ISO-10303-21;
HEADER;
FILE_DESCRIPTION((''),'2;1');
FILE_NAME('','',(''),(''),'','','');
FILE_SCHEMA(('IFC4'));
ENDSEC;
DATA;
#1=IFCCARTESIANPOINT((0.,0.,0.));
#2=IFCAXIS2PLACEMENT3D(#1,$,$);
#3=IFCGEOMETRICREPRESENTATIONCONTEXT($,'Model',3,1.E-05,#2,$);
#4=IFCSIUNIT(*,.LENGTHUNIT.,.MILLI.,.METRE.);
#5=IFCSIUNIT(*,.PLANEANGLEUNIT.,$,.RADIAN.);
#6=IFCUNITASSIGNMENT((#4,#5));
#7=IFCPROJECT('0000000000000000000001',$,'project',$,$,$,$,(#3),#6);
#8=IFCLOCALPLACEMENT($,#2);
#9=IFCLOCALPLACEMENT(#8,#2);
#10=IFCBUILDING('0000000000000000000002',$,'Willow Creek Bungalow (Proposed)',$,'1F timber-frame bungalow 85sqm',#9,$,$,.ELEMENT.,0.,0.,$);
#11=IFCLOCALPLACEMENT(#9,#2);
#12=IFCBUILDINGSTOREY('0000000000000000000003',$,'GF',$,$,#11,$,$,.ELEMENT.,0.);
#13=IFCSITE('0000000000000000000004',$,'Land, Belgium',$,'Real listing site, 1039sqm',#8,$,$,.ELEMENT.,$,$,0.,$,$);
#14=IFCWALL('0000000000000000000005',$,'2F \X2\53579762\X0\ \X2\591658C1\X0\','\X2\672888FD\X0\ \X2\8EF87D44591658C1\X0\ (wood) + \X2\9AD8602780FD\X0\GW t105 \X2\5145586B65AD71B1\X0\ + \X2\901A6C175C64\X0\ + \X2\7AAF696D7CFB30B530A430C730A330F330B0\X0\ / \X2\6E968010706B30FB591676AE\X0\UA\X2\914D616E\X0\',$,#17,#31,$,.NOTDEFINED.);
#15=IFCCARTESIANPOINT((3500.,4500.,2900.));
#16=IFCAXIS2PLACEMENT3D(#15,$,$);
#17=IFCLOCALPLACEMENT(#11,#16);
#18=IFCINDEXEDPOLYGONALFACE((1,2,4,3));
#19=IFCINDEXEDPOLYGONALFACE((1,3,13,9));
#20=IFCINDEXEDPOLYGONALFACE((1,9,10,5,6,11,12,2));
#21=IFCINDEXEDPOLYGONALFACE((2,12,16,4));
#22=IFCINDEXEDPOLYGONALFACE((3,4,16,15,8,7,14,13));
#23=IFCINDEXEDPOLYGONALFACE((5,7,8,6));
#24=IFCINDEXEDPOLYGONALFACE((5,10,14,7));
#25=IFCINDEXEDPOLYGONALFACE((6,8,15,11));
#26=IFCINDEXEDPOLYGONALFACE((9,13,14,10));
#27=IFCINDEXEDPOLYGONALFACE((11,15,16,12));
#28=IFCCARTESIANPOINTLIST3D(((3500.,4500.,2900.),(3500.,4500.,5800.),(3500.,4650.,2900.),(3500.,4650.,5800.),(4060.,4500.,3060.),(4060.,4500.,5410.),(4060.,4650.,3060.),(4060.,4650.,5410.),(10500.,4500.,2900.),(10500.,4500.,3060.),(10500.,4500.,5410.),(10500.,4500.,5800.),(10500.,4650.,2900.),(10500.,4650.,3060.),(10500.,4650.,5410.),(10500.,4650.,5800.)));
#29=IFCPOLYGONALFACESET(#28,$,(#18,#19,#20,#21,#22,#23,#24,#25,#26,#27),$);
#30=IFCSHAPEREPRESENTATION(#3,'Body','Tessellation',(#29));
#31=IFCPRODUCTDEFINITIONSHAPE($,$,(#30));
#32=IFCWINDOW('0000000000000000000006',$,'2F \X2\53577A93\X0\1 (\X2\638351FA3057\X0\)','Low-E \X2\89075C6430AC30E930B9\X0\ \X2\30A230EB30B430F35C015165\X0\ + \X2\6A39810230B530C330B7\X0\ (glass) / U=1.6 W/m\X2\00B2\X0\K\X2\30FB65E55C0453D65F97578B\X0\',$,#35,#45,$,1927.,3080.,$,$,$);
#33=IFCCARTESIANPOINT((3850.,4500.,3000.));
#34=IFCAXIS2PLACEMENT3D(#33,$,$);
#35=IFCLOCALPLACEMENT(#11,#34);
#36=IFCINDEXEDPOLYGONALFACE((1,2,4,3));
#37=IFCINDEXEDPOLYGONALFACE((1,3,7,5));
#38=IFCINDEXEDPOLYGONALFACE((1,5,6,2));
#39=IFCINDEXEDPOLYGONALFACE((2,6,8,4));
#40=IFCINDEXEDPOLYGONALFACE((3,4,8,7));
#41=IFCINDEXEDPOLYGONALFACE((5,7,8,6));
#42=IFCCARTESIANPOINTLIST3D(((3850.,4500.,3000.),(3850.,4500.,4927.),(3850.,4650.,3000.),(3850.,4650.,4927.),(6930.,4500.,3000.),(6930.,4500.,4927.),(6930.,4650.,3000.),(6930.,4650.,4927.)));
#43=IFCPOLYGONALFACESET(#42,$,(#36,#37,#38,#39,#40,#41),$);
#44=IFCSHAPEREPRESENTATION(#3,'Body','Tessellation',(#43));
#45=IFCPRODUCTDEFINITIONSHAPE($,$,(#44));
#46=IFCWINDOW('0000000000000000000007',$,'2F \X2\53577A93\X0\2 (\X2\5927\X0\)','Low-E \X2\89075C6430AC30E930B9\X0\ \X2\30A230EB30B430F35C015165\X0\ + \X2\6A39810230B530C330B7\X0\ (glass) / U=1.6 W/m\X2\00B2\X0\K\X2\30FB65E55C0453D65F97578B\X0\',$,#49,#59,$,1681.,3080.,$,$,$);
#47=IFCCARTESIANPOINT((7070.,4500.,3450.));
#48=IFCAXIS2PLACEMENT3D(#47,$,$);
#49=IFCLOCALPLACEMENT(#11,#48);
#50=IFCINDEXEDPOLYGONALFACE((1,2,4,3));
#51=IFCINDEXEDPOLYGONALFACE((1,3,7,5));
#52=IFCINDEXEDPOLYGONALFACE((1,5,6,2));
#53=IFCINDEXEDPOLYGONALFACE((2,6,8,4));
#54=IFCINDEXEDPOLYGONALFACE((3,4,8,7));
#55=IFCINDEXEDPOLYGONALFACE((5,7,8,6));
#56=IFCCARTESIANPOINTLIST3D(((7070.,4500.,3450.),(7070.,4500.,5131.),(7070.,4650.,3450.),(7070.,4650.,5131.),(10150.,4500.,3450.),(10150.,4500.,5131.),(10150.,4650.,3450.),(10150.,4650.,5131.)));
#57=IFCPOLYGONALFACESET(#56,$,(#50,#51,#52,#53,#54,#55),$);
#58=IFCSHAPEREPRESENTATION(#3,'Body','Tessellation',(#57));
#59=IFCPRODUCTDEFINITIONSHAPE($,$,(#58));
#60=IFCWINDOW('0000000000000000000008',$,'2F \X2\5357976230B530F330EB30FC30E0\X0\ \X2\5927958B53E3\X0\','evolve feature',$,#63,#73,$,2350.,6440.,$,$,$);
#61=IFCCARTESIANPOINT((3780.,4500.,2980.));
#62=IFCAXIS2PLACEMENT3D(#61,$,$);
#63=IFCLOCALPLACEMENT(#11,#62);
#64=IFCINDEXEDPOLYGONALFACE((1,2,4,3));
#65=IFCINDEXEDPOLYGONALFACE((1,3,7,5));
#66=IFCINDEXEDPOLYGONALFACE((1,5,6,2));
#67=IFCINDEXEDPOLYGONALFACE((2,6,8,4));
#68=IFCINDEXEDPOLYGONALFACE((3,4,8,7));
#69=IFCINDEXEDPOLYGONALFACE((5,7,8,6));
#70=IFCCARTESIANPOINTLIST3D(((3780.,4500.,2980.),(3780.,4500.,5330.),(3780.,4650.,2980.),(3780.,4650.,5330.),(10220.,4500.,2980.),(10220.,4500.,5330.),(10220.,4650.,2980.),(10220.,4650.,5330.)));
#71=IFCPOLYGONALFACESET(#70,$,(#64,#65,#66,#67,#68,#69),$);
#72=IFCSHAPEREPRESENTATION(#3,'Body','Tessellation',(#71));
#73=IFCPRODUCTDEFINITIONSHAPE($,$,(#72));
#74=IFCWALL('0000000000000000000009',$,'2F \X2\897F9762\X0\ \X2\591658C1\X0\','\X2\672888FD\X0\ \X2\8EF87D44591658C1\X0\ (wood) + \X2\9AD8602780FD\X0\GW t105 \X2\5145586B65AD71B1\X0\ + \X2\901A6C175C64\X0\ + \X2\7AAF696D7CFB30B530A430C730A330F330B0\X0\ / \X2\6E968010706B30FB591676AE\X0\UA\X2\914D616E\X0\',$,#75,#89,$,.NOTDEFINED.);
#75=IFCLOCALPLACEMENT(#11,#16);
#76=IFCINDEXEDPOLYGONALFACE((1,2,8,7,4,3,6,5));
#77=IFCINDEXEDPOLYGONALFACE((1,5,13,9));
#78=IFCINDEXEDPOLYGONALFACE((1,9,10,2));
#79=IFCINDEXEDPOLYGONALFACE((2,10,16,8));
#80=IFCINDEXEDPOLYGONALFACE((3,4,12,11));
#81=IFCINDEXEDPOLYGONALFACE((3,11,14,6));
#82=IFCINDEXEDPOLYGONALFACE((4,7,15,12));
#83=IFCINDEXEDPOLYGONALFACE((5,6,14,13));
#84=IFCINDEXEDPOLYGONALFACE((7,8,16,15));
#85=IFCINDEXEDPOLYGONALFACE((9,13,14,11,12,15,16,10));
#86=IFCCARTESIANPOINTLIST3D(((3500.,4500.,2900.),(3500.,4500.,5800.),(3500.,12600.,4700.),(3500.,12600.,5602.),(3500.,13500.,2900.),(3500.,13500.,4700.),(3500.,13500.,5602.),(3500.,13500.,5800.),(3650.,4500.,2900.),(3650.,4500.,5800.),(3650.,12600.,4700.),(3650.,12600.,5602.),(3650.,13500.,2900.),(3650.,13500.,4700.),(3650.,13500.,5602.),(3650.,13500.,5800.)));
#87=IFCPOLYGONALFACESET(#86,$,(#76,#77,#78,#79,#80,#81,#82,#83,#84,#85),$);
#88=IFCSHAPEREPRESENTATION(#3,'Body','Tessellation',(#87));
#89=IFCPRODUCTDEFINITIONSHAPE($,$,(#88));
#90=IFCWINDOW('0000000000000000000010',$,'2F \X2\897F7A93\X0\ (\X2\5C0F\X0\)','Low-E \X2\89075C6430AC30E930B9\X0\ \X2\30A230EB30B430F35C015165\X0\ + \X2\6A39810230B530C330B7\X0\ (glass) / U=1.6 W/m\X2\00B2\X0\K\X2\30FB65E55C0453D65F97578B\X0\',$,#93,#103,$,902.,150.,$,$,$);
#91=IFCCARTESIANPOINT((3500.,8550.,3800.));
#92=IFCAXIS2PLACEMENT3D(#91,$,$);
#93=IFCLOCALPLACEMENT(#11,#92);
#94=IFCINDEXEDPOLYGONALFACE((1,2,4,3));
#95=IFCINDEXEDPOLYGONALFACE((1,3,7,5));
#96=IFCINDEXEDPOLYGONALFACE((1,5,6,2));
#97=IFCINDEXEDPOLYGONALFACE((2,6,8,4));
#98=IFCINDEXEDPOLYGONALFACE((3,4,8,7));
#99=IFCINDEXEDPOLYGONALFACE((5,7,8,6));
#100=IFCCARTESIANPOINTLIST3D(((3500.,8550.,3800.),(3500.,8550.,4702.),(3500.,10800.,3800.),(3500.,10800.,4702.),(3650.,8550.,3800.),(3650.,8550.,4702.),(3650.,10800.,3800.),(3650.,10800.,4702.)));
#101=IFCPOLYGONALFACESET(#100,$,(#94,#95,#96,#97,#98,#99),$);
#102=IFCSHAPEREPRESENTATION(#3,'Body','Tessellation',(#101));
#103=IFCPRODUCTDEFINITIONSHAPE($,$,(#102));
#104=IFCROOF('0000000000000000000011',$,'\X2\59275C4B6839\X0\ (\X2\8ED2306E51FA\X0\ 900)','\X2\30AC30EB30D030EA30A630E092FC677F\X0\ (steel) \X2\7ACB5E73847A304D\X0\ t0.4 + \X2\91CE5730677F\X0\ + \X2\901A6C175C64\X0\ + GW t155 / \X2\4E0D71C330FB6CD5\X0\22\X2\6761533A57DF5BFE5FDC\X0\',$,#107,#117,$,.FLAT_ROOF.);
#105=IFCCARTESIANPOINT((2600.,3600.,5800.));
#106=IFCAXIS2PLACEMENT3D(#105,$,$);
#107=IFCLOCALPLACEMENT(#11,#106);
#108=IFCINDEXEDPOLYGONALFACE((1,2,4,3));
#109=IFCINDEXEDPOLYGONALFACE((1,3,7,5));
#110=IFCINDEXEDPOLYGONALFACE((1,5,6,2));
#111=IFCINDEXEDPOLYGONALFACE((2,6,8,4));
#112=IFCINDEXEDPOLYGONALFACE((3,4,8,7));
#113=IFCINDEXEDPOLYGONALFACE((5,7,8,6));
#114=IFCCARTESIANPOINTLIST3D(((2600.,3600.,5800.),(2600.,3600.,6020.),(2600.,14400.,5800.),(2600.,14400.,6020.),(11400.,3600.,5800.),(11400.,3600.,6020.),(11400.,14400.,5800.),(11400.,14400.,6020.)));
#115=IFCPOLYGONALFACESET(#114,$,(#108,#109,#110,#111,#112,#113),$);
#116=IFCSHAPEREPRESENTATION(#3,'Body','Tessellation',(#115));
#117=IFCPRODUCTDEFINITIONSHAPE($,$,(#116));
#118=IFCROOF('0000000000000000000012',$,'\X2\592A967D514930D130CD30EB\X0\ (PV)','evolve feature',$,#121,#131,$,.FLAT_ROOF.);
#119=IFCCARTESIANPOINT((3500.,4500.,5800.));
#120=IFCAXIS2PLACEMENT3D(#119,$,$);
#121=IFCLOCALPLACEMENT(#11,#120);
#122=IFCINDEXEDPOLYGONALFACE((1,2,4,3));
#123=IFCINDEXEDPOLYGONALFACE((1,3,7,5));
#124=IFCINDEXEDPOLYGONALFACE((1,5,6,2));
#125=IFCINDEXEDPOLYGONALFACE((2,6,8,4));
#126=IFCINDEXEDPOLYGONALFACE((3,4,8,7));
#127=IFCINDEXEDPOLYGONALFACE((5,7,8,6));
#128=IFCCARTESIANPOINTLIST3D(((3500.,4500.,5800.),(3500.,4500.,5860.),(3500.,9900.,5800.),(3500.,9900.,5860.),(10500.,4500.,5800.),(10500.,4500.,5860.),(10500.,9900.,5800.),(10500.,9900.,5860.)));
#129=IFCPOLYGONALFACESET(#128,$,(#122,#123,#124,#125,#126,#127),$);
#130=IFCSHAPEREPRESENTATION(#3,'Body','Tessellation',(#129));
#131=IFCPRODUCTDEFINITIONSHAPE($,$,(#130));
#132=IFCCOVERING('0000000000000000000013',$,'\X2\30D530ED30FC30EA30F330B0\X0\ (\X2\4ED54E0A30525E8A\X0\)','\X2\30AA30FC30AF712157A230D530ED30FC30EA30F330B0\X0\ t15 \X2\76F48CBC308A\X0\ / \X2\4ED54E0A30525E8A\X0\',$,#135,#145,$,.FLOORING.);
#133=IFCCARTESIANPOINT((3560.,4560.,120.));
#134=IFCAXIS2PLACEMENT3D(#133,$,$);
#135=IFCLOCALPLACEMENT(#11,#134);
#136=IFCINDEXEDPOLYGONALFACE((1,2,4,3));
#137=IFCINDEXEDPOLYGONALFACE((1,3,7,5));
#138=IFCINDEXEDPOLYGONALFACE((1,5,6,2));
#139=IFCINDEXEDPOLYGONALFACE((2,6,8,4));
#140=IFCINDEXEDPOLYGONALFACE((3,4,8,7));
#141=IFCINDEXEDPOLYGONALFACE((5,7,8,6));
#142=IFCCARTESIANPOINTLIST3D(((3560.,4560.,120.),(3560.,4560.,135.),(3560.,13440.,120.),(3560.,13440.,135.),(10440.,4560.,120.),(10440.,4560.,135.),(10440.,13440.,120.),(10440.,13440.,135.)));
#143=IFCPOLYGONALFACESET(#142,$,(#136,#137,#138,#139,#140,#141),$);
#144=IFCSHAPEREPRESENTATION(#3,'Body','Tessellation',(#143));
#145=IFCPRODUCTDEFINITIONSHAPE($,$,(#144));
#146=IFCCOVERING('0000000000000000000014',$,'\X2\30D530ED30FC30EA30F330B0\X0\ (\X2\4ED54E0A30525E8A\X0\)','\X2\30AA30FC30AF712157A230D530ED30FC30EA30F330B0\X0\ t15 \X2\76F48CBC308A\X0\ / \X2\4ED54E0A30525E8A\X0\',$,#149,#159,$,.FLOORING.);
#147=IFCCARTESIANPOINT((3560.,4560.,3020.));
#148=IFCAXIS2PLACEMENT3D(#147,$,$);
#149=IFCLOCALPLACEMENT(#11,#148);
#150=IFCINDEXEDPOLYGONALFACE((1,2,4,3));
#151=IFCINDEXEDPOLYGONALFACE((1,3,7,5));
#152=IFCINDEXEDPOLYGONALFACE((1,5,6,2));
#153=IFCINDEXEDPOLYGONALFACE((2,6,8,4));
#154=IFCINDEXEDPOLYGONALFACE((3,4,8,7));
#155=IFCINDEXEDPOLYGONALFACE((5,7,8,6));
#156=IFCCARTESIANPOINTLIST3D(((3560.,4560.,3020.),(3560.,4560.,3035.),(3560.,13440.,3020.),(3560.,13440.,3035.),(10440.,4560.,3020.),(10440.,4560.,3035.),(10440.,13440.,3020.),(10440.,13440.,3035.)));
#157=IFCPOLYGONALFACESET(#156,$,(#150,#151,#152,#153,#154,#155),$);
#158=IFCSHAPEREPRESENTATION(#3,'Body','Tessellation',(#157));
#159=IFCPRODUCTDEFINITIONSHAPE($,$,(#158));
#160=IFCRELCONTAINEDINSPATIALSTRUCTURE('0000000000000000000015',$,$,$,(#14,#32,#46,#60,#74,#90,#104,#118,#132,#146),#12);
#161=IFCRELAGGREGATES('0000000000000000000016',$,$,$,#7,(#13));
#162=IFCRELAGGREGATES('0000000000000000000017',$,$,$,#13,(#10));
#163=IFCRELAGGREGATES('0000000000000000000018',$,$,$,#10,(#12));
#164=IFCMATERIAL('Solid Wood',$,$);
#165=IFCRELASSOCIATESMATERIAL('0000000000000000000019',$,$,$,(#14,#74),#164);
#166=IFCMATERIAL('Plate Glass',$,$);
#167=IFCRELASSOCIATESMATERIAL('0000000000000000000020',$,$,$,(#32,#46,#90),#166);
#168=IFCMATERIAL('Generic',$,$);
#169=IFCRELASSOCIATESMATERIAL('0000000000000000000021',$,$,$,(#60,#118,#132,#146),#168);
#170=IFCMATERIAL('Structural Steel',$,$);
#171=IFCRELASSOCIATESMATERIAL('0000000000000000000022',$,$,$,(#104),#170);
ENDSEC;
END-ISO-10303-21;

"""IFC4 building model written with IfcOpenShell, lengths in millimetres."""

from ifc_helpers import new_model, si_unit, frame, frame_2d, origin, place, context, project, spatial, rectangle, extrude, material, element, fill, save


model = new_model("IFC4")

# Units and contexts
model_context = context("Model", 3, precision=1e-05, world=origin())
ifc_project = project(units=[si_unit("LENGTHUNIT", "METRE", prefix="MILLI"), si_unit("PLANEANGLEUNIT", "RADIAN")], contexts=[model_context])

# Site, building, storey
site_placement = place(None, origin())
site = spatial("IfcSite", under=ifc_project, at=site_placement, Name="Land, Belgium", ObjectType="Real listing site, 1039sqm", CompositionType="ELEMENT", RefElevation=0.0)
building_placement = place(site_placement, origin())
building = spatial("IfcBuilding", under=site, at=building_placement, Name="Willow Creek Bungalow (Proposed)", ObjectType="1F timber-frame bungalow 85sqm", CompositionType="ELEMENT", ElevationOfRefHeight=0.0, ElevationOfTerrain=0.0)
storey_placement = place(building_placement, origin())
storey = spatial("IfcBuildingStorey", under=building, at=storey_placement, Name="GF", CompositionType="ELEMENT", Elevation=0.0)

# Shared definitions
ifc_material_1 = material(Name="Solid Wood")
ifc_material_2 = material(Name="Generic")

# Shared definitions
ifc_material_3 = material(Name="Plate Glass")

# Wall, openings, windows
wall_1_placement = place(storey_placement, frame((3500.0, 4500.0, 2900.0)))
wall_1 = element("IfcWall", 1, at=wall_1_placement, inside=storey, material=ifc_material_1, Name="2F 南面 外壁", Description="木製 軸組外壁 (wood) + 高性能GW t105 充填断熱 + 通気層 + 窯業系サイディング / 準耐火・外皮UA配慮", PredefinedType="NOTDEFINED", context=model_context, shape_type="SweptSolid", body=[
    extrude(rectangle(XDim=7000.0, YDim=150.0, at=frame_2d((3500.0, 75.0))), frame((3500.0, 4500.0, 2900.0)), (0.0, 0.0, 1.0), 2900.0),
])
opening_1_placement = place(storey_placement, frame((3850.0, 4500.0, 3000.0)))
opening_1 = element("IfcOpeningElement", 2, at=opening_1_placement, cuts=wall_1, PredefinedType="NOTDEFINED", context=model_context, shape_type="SweptSolid", body=[
    extrude(rectangle(XDim=3080.0, YDim=150.0, at=frame_2d((1540.0, 75.0))), frame((3850.0, 4500.0, 3000.0)), (0.0, 0.0, 1.0), 1927.0),
])
opening_2_placement = place(storey_placement, frame((7070.0, 4500.0, 3450.0)))
opening_2 = element("IfcOpeningElement", 3, at=opening_2_placement, cuts=wall_1, PredefinedType="NOTDEFINED", context=model_context, shape_type="SweptSolid", body=[
    extrude(rectangle(XDim=3080.0, YDim=150.0, at=frame_2d((1540.0, 75.0))), frame((7070.0, 4500.0, 3450.0)), (0.0, 0.0, 1.0), 1681.0),
])
opening_3_placement = place(storey_placement, frame((3780.0, 4500.0, 2980.0)))
opening_3 = element("IfcOpeningElement", 4, at=opening_3_placement, cuts=wall_1, PredefinedType="NOTDEFINED", context=model_context, shape_type="SweptSolid", body=[
    extrude(rectangle(XDim=6440.0, YDim=150.0, at=frame_2d((3220.0, 75.0))), frame((3780.0, 4500.0, 2980.0)), (0.0, 0.0, 1.0), 2350.0),
])
window_1_placement = place(storey_placement, frame((3850.0, 4500.0, 3000.0)))
window_1 = element("IfcWindow", 5, at=window_1_placement, inside=storey, material=ifc_material_3, Name="2F 南窓1 (掃出し)", Description="Low-E 複層ガラス アルゴン封入 + 樹脂サッシ (glass) / U=1.6 W/m²K・日射取得型", OverallHeight=1927.0, OverallWidth=3080.0, context=model_context, shape_type="SweptSolid", body=[
    extrude(rectangle(XDim=3080.0, YDim=150.0, at=frame_2d((1540.0, 75.0))), frame((3850.0, 4500.0, 3000.0)), (0.0, 0.0, 1.0), 1927.0),
])
fill(opening_1, window_1)
window_2_placement = place(storey_placement, frame((7070.0, 4500.0, 3450.0)))
window_2 = element("IfcWindow", 6, at=window_2_placement, inside=storey, material=ifc_material_3, Name="2F 南窓2 (大)", Description="Low-E 複層ガラス アルゴン封入 + 樹脂サッシ (glass) / U=1.6 W/m²K・日射取得型", OverallHeight=1681.0, OverallWidth=3080.0, context=model_context, shape_type="SweptSolid", body=[
    extrude(rectangle(XDim=3080.0, YDim=150.0, at=frame_2d((1540.0, 75.0))), frame((7070.0, 4500.0, 3450.0)), (0.0, 0.0, 1.0), 1681.0),
])
fill(opening_2, window_2)
window_3_placement = place(storey_placement, frame((3780.0, 4500.0, 2980.0)))
window_3 = element("IfcWindow", 7, at=window_3_placement, inside=storey, material=ifc_material_2, Name="2F 南面サンルーム 大開口", Description="evolve feature", OverallHeight=2350.0, OverallWidth=6440.0, context=model_context, shape_type="SweptSolid", body=[
    extrude(rectangle(XDim=6440.0, YDim=150.0, at=frame_2d((3220.0, 75.0))), frame((3780.0, 4500.0, 2980.0)), (0.0, 0.0, 1.0), 2350.0),
])
fill(opening_3, window_3)

# Wall, opening, window
wall_2_placement = place(storey_placement, frame((3500.0, 4500.0, 2900.0)))
wall_2 = element("IfcWall", 8, at=wall_2_placement, inside=storey, material=ifc_material_1, Name="2F 西面 外壁", Description="木製 軸組外壁 (wood) + 高性能GW t105 充填断熱 + 通気層 + 窯業系サイディング / 準耐火・外皮UA配慮", PredefinedType="NOTDEFINED", context=model_context, shape_type="SweptSolid", body=[
    extrude(rectangle(XDim=150.0, YDim=9000.0, at=frame_2d((75.0, 4500.0))), frame((3500.0, 4500.0, 2900.0)), (0.0, 0.0, 1.0), 2900.0),
])
opening_4_placement = place(storey_placement, frame((3500.0, 8550.0, 3800.0)))
opening_4 = element("IfcOpeningElement", 9, at=opening_4_placement, cuts=wall_2, PredefinedType="NOTDEFINED", context=model_context, shape_type="SweptSolid", body=[
    extrude(rectangle(XDim=150.0, YDim=2250.0, at=frame_2d((75.0, 1125.0))), frame((3500.0, 8550.0, 3800.0)), (0.0, 0.0, 1.0), 902.0),
])
window_4_placement = place(storey_placement, frame((3500.0, 8550.0, 3800.0)))
window_4 = element("IfcWindow", 10, at=window_4_placement, inside=storey, material=ifc_material_3, Name="2F 西窓 (小)", Description="Low-E 複層ガラス アルゴン封入 + 樹脂サッシ (glass) / U=1.6 W/m²K・日射取得型", OverallHeight=902.0, OverallWidth=150.0, context=model_context, shape_type="SweptSolid", body=[
    extrude(rectangle(XDim=150.0, YDim=2250.0, at=frame_2d((75.0, 1125.0))), frame((3500.0, 8550.0, 3800.0)), (0.0, 0.0, 1.0), 902.0),
])
fill(opening_4, window_4)

# Roofs
ifc_material_4 = material(Name="Structural Steel")
roof_1_placement = place(storey_placement, frame((2600.0, 3600.0, 5800.0)))
element("IfcRoof", 11, at=roof_1_placement, inside=storey, material=ifc_material_4, Name="大屋根 (軒の出 900)", Description="ガルバリウム鋼板 (steel) 立平葺き t0.4 + 野地板 + 通気層 + GW t155 / 不燃・法22条区域対応", PredefinedType="FLAT_ROOF", context=model_context, shape_type="SweptSolid", body=[
    extrude(rectangle(XDim=8800.0, YDim=10800.0, at=frame_2d((4400.0, 5400.0))), frame((2600.0, 3600.0, 5800.0)), (0.0, 0.0, 1.0), 220.0),
])
roof_2_placement = place(storey_placement, frame((3500.0, 4500.0, 5800.0)))
element("IfcRoof", 12, at=roof_2_placement, inside=storey, material=ifc_material_2, Name="太陽光パネル (PV)", Description="evolve feature", PredefinedType="FLAT_ROOF", context=model_context, shape_type="SweptSolid", body=[
    extrude(rectangle(XDim=7000.0, YDim=5400.0, at=frame_2d((3500.0, 2700.0))), frame((3500.0, 4500.0, 5800.0)), (0.0, 0.0, 1.0), 60.0),
])

# Coverings
covering_1_placement = place(storey_placement, frame((3560.0, 4560.0, 120.0)))
element("IfcCovering", 13, at=covering_1_placement, inside=storey, material=ifc_material_2, Name="フローリング (仕上げ床)", Description="オーク無垢フローリング t15 直貼り / 仕上げ床", PredefinedType="FLOORING", context=model_context, shape_type="SweptSolid", body=[
    extrude(rectangle(XDim=6880.0, YDim=8880.0, at=frame_2d((3440.0, 4440.0))), frame((3560.0, 4560.0, 120.0)), (0.0, 0.0, 1.0), 15.0),
])
covering_2_placement = place(storey_placement, frame((3560.0, 4560.0, 3020.0)))
element("IfcCovering", 14, at=covering_2_placement, inside=storey, material=ifc_material_2, Name="フローリング (仕上げ床)", Description="オーク無垢フローリング t15 直貼り / 仕上げ床", PredefinedType="FLOORING", context=model_context, shape_type="SweptSolid", body=[
    extrude(rectangle(XDim=6880.0, YDim=8880.0, at=frame_2d((3440.0, 4440.0))), frame((3560.0, 4560.0, 3020.0)), (0.0, 0.0, 1.0), 15.0),
])

save(model, "model.ifc")
